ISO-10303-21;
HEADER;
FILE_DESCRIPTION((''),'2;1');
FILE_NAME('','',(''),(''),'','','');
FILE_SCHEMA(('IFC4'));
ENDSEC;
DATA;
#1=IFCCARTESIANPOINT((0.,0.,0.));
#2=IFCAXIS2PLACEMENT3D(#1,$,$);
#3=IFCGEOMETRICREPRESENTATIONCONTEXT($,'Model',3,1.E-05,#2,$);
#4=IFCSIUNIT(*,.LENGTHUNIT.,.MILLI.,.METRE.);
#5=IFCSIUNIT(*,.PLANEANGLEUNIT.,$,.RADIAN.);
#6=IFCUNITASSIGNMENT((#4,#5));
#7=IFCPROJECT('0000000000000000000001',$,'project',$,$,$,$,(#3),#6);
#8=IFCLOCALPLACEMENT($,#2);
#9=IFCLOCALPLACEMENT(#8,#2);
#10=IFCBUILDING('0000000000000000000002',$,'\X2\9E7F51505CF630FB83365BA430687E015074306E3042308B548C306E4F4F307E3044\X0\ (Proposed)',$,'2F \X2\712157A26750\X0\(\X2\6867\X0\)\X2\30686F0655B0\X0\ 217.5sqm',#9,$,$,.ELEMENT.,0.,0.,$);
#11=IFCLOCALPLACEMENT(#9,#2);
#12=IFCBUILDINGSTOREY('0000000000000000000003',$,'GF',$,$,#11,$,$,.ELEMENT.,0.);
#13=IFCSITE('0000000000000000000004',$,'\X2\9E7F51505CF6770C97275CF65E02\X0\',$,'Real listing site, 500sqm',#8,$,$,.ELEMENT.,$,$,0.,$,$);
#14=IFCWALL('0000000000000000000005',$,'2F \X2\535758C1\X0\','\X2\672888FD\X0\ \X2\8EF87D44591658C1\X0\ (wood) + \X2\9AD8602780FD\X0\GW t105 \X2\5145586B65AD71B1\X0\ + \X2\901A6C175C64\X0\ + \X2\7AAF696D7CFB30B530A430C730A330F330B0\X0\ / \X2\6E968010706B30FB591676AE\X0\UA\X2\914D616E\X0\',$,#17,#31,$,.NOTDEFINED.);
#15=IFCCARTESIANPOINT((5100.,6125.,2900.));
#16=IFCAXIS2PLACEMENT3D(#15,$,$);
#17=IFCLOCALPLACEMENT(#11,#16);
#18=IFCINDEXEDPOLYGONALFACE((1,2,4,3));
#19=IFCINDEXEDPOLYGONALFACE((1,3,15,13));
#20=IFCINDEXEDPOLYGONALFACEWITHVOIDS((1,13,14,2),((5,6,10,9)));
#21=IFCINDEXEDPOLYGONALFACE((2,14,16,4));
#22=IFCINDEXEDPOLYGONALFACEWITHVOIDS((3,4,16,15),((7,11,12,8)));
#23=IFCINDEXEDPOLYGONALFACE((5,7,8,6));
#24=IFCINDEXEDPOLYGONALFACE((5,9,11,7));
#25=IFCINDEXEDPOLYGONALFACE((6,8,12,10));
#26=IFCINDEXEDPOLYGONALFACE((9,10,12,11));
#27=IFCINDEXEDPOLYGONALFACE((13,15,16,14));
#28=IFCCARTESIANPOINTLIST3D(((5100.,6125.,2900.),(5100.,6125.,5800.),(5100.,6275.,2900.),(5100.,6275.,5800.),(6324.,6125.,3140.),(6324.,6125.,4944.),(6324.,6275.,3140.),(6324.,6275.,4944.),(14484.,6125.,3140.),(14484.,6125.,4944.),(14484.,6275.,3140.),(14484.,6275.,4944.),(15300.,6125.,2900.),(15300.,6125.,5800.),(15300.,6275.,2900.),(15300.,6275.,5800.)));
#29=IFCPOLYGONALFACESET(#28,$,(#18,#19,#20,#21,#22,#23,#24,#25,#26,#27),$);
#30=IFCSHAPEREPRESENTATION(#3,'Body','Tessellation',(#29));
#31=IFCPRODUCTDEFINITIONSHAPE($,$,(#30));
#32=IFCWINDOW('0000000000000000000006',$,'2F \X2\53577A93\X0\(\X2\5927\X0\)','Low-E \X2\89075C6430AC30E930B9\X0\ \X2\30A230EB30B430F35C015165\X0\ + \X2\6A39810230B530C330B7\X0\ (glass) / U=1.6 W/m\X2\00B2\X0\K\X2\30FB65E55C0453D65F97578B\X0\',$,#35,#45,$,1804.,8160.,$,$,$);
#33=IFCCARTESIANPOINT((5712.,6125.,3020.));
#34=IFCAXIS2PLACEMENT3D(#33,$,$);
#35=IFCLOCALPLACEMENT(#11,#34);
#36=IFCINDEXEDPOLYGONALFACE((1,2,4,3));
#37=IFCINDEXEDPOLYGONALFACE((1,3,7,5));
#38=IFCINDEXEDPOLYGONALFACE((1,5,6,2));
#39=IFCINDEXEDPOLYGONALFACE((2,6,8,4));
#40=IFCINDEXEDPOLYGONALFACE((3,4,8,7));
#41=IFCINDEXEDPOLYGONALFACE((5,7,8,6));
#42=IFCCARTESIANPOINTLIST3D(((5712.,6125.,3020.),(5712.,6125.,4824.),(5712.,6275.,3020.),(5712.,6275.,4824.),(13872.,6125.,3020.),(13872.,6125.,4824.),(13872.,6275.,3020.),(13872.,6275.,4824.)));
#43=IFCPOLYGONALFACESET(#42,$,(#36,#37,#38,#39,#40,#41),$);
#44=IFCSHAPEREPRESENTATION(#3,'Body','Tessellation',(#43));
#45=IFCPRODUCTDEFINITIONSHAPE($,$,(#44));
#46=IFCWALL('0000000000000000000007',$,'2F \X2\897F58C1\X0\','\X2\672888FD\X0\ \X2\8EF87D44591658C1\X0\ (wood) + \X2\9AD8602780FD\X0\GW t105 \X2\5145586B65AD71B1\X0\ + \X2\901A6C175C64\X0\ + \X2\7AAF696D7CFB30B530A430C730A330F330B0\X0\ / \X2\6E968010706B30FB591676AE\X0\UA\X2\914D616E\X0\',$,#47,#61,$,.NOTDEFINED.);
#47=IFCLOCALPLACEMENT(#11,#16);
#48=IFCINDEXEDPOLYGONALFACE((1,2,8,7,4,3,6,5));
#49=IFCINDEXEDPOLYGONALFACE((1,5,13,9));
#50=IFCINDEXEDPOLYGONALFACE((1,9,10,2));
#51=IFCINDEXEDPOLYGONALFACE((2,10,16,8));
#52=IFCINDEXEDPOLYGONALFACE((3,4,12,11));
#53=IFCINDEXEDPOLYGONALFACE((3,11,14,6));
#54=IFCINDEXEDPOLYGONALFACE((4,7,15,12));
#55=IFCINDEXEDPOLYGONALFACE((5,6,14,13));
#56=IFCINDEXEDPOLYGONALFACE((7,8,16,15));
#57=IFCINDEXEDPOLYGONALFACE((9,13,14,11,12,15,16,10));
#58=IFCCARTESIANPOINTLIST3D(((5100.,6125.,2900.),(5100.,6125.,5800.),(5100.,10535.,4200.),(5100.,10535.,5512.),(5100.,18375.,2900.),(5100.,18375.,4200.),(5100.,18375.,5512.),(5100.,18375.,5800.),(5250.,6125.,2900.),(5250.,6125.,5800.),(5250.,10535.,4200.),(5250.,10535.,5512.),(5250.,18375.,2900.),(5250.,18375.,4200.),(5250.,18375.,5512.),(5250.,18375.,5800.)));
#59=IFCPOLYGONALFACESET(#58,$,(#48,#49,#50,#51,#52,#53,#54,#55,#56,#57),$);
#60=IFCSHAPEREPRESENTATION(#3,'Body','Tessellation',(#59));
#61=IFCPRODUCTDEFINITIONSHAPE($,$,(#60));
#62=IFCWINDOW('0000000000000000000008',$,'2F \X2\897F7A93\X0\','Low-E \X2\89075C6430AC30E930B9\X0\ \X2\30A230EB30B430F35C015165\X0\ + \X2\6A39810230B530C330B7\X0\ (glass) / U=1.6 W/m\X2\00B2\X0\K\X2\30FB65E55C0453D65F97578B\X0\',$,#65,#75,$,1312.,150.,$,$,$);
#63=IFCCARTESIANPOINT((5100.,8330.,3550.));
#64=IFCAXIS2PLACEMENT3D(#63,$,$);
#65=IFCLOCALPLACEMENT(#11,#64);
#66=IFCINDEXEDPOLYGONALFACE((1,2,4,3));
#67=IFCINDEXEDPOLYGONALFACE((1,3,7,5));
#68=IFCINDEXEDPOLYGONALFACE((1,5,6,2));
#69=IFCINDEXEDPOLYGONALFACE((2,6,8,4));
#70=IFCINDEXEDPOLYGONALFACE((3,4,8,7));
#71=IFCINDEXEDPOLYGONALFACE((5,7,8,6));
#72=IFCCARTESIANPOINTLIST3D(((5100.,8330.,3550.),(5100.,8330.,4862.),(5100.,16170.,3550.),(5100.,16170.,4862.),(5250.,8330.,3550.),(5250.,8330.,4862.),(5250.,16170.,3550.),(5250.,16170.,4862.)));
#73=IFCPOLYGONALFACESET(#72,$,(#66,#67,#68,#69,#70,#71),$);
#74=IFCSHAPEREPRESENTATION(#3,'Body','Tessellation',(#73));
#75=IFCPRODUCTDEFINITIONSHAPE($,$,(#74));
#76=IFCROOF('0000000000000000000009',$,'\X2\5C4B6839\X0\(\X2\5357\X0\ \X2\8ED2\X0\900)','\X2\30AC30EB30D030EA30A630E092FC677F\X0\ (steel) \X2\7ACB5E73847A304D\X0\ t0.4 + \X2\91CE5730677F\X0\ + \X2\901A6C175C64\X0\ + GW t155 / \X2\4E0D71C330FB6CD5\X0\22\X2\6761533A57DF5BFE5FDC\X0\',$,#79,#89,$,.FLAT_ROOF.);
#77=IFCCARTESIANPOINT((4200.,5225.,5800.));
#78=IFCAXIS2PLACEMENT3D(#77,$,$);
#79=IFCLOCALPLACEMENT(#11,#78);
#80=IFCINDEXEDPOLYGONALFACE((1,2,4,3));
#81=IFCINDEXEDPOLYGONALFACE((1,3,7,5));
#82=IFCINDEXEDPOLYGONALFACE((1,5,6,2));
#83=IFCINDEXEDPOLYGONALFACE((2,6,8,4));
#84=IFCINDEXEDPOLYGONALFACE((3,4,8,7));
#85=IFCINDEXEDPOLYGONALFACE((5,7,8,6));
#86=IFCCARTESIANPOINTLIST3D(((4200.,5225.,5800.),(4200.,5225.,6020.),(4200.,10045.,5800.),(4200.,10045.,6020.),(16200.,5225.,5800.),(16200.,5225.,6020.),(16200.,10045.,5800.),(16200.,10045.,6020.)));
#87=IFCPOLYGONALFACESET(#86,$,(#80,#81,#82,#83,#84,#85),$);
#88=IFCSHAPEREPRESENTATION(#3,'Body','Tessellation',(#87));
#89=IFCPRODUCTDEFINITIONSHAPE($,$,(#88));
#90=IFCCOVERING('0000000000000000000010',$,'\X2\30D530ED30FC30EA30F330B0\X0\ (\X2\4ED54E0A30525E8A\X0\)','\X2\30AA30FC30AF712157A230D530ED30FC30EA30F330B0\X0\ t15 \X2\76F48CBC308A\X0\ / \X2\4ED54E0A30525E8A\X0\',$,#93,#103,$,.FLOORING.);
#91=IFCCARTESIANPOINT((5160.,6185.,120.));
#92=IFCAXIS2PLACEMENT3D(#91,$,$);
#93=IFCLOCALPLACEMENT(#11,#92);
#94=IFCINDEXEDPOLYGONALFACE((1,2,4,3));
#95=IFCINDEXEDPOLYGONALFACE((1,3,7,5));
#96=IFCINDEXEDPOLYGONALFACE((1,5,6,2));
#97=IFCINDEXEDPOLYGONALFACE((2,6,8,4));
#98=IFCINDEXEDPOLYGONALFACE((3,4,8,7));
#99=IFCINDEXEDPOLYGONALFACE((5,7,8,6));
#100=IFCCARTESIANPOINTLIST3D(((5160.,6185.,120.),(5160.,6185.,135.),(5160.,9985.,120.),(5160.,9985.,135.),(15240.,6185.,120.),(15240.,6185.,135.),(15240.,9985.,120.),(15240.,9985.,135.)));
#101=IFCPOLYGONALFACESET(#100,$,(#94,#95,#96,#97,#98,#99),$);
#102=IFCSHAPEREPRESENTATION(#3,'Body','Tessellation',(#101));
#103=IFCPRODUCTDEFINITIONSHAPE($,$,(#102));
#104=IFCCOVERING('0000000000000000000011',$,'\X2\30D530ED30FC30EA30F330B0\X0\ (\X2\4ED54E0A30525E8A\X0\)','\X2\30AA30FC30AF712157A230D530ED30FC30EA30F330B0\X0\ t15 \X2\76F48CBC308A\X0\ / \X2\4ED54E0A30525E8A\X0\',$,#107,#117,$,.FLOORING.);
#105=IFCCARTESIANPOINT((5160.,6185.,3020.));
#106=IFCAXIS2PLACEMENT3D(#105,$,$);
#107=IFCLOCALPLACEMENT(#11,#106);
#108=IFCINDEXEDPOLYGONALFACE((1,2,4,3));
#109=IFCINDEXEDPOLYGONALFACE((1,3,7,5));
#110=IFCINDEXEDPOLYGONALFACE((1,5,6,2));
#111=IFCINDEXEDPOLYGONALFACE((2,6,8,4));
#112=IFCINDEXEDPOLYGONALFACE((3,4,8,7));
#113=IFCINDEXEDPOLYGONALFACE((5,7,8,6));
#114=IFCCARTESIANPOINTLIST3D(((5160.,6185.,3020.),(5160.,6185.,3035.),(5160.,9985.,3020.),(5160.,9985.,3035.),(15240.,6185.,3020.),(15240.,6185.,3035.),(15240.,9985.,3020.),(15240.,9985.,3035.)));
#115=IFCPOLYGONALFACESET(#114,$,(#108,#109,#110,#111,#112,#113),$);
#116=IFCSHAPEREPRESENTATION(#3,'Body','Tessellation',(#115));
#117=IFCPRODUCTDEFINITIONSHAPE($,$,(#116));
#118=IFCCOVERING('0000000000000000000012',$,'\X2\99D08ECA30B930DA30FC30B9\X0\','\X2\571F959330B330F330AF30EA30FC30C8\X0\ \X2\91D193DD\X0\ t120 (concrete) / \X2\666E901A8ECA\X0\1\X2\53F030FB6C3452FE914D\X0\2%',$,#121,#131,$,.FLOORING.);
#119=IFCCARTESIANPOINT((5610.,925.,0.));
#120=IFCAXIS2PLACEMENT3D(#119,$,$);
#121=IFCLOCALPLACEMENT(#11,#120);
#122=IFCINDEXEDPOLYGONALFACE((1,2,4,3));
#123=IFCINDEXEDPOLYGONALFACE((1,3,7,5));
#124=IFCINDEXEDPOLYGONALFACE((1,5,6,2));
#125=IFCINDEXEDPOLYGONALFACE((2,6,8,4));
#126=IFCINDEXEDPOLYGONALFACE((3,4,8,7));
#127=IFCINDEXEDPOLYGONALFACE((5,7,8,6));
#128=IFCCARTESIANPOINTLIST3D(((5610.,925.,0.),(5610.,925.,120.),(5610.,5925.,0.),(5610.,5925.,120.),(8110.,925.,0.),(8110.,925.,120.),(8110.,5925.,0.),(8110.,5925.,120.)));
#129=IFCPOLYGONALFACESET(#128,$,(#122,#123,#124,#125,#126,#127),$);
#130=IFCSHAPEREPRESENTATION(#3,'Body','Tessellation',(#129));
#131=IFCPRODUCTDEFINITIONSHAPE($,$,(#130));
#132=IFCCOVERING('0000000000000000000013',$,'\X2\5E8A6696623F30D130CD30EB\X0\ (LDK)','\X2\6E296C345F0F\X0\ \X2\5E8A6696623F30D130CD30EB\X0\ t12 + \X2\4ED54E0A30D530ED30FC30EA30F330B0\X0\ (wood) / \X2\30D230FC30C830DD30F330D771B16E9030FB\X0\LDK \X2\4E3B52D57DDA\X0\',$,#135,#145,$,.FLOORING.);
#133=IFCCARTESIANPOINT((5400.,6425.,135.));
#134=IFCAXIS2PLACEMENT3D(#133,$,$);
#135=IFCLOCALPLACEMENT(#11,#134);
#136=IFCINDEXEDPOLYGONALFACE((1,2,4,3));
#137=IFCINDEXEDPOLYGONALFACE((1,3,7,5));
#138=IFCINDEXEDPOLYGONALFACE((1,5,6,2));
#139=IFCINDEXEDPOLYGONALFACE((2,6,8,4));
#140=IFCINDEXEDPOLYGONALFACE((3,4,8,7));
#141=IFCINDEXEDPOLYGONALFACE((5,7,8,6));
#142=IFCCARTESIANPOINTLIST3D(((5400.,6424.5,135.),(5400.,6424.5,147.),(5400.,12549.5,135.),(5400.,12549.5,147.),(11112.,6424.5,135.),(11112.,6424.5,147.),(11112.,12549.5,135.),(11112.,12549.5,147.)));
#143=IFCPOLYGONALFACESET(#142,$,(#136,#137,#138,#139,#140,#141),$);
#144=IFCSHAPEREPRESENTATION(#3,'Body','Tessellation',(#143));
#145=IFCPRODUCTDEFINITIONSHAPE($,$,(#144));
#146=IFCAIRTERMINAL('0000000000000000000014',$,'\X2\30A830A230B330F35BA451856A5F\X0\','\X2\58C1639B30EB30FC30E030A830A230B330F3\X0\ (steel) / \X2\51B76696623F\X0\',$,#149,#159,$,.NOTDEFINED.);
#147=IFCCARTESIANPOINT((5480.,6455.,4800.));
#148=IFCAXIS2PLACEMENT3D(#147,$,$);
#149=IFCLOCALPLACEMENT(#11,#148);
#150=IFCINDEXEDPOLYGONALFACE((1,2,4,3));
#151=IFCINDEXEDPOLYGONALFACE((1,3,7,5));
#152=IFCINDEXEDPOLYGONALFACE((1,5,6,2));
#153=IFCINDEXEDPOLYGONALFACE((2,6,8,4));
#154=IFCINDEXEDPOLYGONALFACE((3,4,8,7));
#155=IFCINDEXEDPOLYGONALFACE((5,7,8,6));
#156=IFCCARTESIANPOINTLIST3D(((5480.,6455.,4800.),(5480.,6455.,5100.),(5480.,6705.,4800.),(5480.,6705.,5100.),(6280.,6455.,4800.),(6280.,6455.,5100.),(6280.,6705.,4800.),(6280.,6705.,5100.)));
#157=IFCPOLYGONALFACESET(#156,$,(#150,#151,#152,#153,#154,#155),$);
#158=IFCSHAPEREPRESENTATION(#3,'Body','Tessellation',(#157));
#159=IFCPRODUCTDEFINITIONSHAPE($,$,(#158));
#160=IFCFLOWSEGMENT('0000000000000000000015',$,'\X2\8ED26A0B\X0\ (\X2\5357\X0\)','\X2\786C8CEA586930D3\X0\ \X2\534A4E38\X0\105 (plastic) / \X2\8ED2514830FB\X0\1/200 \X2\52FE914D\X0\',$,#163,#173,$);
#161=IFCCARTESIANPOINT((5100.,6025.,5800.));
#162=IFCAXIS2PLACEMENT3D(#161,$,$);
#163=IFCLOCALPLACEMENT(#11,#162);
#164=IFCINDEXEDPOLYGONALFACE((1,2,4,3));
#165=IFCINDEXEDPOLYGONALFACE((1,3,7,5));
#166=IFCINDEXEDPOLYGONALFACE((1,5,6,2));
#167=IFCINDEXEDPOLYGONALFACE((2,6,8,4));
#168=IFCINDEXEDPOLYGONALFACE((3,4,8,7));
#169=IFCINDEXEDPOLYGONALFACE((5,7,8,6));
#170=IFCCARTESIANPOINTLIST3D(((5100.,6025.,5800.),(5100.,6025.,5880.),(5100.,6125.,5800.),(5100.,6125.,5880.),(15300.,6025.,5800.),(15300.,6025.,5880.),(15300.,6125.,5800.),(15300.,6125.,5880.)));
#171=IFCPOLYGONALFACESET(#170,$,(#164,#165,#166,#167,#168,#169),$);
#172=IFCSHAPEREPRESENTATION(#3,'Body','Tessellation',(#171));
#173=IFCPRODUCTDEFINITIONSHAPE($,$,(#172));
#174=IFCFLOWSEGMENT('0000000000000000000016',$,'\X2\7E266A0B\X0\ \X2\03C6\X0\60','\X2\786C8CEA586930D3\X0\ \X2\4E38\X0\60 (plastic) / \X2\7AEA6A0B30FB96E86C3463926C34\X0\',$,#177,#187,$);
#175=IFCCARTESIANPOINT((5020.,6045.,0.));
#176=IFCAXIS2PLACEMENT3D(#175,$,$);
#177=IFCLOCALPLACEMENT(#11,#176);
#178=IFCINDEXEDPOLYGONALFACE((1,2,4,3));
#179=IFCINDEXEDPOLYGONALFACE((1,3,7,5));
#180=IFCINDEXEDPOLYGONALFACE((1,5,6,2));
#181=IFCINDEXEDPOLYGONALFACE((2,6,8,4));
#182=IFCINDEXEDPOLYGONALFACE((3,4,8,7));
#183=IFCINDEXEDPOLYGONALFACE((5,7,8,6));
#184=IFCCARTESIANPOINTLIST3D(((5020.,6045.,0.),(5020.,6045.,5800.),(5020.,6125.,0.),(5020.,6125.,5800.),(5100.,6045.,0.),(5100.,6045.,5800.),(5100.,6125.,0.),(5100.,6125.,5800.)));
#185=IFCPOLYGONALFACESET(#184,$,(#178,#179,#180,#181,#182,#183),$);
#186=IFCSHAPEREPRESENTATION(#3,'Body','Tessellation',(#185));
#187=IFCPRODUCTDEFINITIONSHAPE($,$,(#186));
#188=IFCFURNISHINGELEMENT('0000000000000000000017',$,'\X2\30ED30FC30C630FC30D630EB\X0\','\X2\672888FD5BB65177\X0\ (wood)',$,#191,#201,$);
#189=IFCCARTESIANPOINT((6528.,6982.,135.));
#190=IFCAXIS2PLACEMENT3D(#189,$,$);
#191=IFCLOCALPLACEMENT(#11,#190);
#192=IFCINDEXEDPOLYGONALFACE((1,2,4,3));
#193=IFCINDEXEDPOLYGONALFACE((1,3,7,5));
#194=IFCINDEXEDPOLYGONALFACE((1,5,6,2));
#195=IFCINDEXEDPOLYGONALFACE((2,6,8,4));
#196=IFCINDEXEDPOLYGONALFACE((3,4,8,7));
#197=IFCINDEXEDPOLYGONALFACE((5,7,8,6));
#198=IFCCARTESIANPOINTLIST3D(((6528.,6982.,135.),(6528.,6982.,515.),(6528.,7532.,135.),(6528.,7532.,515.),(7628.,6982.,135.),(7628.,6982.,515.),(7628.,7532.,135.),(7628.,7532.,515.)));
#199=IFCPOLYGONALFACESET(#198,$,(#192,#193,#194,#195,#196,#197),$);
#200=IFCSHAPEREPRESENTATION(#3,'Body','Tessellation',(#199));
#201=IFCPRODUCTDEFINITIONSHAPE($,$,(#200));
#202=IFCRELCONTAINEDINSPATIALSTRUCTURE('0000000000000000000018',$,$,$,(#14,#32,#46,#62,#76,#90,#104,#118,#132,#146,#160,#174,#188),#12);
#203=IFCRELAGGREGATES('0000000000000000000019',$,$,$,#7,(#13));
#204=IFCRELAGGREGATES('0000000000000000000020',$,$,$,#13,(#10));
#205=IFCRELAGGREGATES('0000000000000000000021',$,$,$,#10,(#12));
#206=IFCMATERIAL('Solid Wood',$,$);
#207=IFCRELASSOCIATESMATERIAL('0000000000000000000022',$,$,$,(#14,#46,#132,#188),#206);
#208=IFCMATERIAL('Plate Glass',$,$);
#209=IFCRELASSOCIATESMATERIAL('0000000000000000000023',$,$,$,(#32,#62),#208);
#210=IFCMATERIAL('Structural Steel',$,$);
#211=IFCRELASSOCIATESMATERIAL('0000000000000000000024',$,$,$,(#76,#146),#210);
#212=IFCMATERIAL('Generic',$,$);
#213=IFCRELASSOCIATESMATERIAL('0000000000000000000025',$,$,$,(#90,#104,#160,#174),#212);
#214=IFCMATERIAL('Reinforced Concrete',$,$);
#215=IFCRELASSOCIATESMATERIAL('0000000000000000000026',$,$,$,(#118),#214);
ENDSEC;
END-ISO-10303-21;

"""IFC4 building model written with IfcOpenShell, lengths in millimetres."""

from ifc_helpers import new_model, si_unit, frame, frame_2d, origin, place, context, project, spatial, rectangle, extrude, material, element, fill, save


model = new_model("IFC4")

# Units and contexts
model_context = context("Model", 3, precision=1e-05, world=origin())
ifc_project = project(units=[si_unit("LENGTHUNIT", "METRE", prefix="MILLI"), si_unit("PLANEANGLEUNIT", "RADIAN")], contexts=[model_context])

# Site, building, storey
site_placement = place(None, origin())
site = spatial("IfcSite", under=ifc_project, at=site_placement, Name="鹿児島県霧島市", ObjectType="Real listing site, 500sqm", CompositionType="ELEMENT", RefElevation=0.0)
building_placement = place(site_placement, origin())
building = spatial("IfcBuilding", under=site, at=building_placement, Name="鹿児島・茶室と縁側のある和の住まい (Proposed)", ObjectType="2F 無垢材(桧)と漆喰 217.5sqm", CompositionType="ELEMENT", ElevationOfRefHeight=0.0, ElevationOfTerrain=0.0)
storey_placement = place(building_placement, origin())
storey = spatial("IfcBuildingStorey", under=building, at=storey_placement, Name="GF", CompositionType="ELEMENT", Elevation=0.0)

# Shared definitions
ifc_material_1 = material(Name="Solid Wood")

# Shared definitions
ifc_material_2 = material(Name="Reinforced Concrete")

# Shared definitions
ifc_material_3 = material(Name="Plate Glass")

# Walls, openings, windows
wall_1_placement = place(storey_placement, frame((5100.0, 6125.0, 2900.0)))
wall_1 = element("IfcWall", 1, at=wall_1_placement, inside=storey, material=ifc_material_1, Name="2F 南壁", Description="木製 軸組外壁 (wood) + 高性能GW t105 充填断熱 + 通気層 + 窯業系サイディング / 準耐火・外皮UA配慮", PredefinedType="NOTDEFINED", context=model_context, shape_type="SweptSolid", body=[
    extrude(rectangle(XDim=10200.0, YDim=150.0, at=frame_2d((5100.0, 75.0))), frame((5100.0, 6125.0, 2900.0)), (0.0, 0.0, 1.0), 2900.0),
])
opening_1_placement = place(storey_placement, frame((5712.0, 6125.0, 3020.0)))
opening_1 = element("IfcOpeningElement", 2, at=opening_1_placement, cuts=wall_1, PredefinedType="NOTDEFINED", context=model_context, shape_type="SweptSolid", body=[
    extrude(rectangle(XDim=8160.0, YDim=150.0, at=frame_2d((4080.0, 75.0))), frame((5712.0, 6125.0, 3020.0)), (0.0, 0.0, 1.0), 1804.0),
])
window_1_placement = place(storey_placement, frame((5712.0, 6125.0, 3020.0)))
window_1 = element("IfcWindow", 3, at=window_1_placement, inside=storey, material=ifc_material_3, Name="2F 南窓(大)", Description="Low-E 複層ガラス アルゴン封入 + 樹脂サッシ (glass) / U=1.6 W/m²K・日射取得型", OverallHeight=1804.0, OverallWidth=8160.0, context=model_context, shape_type="SweptSolid", body=[
    extrude(rectangle(XDim=8160.0, YDim=150.0, at=frame_2d((4080.0, 75.0))), frame((5712.0, 6125.0, 3020.0)), (0.0, 0.0, 1.0), 1804.0),
])
fill(opening_1, window_1)
wall_2_placement = place(storey_placement, frame((5100.0, 6125.0, 2900.0)))
wall_2 = element("IfcWall", 4, at=wall_2_placement, inside=storey, material=ifc_material_1, Name="2F 西壁", Description="木製 軸組外壁 (wood) + 高性能GW t105 充填断熱 + 通気層 + 窯業系サイディング / 準耐火・外皮UA配慮", PredefinedType="NOTDEFINED", context=model_context, shape_type="SweptSolid", body=[
    extrude(rectangle(XDim=150.0, YDim=12250.0, at=frame_2d((75.0, 6125.0))), frame((5100.0, 6125.0, 2900.0)), (0.0, 0.0, 1.0), 2900.0),
])
opening_2_placement = place(storey_placement, frame((5100.0, 8330.0, 3550.0)))
opening_2 = element("IfcOpeningElement", 5, at=opening_2_placement, cuts=wall_2, PredefinedType="NOTDEFINED", context=model_context, shape_type="SweptSolid", body=[
    extrude(rectangle(XDim=150.0, YDim=7840.0, at=frame_2d((75.0, 3920.0))), frame((5100.0, 8330.0, 3550.0)), (0.0, 0.0, 1.0), 1312.0),
])
window_2_placement = place(storey_placement, frame((5100.0, 8330.0, 3550.0)))
window_2 = element("IfcWindow", 6, at=window_2_placement, inside=storey, material=ifc_material_3, Name="2F 西窓", Description="Low-E 複層ガラス アルゴン封入 + 樹脂サッシ (glass) / U=1.6 W/m²K・日射取得型", OverallHeight=1312.0, OverallWidth=150.0, context=model_context, shape_type="SweptSolid", body=[
    extrude(rectangle(XDim=150.0, YDim=7840.0, at=frame_2d((75.0, 3920.0))), frame((5100.0, 8330.0, 3550.0)), (0.0, 0.0, 1.0), 1312.0),
])
fill(opening_2, window_2)

# Roof
ifc_material_4 = material(Name="Structural Steel")
for number, where, name in (
    (7, (4200.0, 5225.0, 5800.0), "屋根(南 軒900)"),
):
    element("IfcRoof", number, at=place(storey_placement, frame(where)), inside=storey, material=ifc_material_4, Name=name, Description="ガルバリウム鋼板 (steel) 立平葺き t0.4 + 野地板 + 通気層 + GW t155 / 不燃・法22条区域対応", PredefinedType="FLAT_ROOF", context=model_context, shape_type="SweptSolid", body=[
        extrude(rectangle(XDim=12000.0, YDim=4820.0, at=frame_2d((6000.0, 2410.0))), frame((4200.0, 5225.0, 5800.0)), (0.0, 0.0, 1.0), 220.0),
    ])

# Coverings
ifc_material_5 = material(Name="Generic")
covering_1_placement = place(storey_placement, frame((5160.0, 6185.0, 120.0)))
element("IfcCovering", 8, at=covering_1_placement, inside=storey, material=ifc_material_5, Name="フローリング (仕上げ床)", Description="オーク無垢フローリング t15 直貼り / 仕上げ床", PredefinedType="FLOORING", context=model_context, shape_type="SweptSolid", body=[
    extrude(rectangle(XDim=10080.0, YDim=3800.0, at=frame_2d((5040.0, 1900.0))), frame((5160.0, 6185.0, 120.0)), (0.0, 0.0, 1.0), 15.0),
])
covering_2_placement = place(storey_placement, frame((5160.0, 6185.0, 3020.0)))
element("IfcCovering", 9, at=covering_2_placement, inside=storey, material=ifc_material_5, Name="フローリング (仕上げ床)", Description="オーク無垢フローリング t15 直貼り / 仕上げ床", PredefinedType="FLOORING", context=model_context, shape_type="SweptSolid", body=[
    extrude(rectangle(XDim=10080.0, YDim=3800.0, at=frame_2d((5040.0, 1900.0))), frame((5160.0, 6185.0, 3020.0)), (0.0, 0.0, 1.0), 15.0),
])
covering_3_placement = place(storey_placement, frame((5610.0, 925.0, 0.0)))
element("IfcCovering", 10, at=covering_3_placement, inside=storey, material=ifc_material_2, Name="駐車スペース", Description="土間コンクリート 金鏝 t120 (concrete) / 普通車1台・水勾配2%", PredefinedType="FLOORING", context=model_context, shape_type="SweptSolid", body=[
    extrude(rectangle(XDim=2500.0, YDim=5000.0, at=frame_2d((1250.0, 2500.0))), frame((5610.0, 925.0, 0.0)), (0.0, 0.0, 1.0), 120.0),
])
covering_4_placement = place(storey_placement, frame((5400.0, 6425.0, 135.0)))
element("IfcCovering", 11, at=covering_4_placement, inside=storey, material=ifc_material_1, Name="床暖房パネル (LDK)", Description="温水式 床暖房パネル t12 + 仕上フローリング (wood) / ヒートポンプ熱源・LDK 主動線", PredefinedType="FLOORING", context=model_context, shape_type="SweptSolid", body=[
    extrude(rectangle(XDim=5712.0, YDim=6125.0, at=frame_2d((2856.0, 3062.0))), frame((5400.0, 6425.0, 135.0)), (0.0, 0.0, 1.0), 12.0),
])

# Air terminal
air_terminal_placement = place(storey_placement, frame((5480.0, 6455.0, 4800.0)))
element("IfcAirTerminal", 12, at=air_terminal_placement, inside=storey, material=ifc_material_4, Name="エアコン室内機", Description="壁掛ルームエアコン (steel) / 冷暖房", PredefinedType="NOTDEFINED", context=model_context, shape_type="SweptSolid", body=[
    extrude(rectangle(XDim=800.0, YDim=250.0, at=frame_2d((400.0, 125.0))), frame((5480.0, 6455.0, 4800.0)), (0.0, 0.0, 1.0), 300.0),
])

# Flow segments
flow_segment_1_placement = place(storey_placement, frame((5100.0, 6025.0, 5800.0)))
element("IfcFlowSegment", 13, at=flow_segment_1_placement, inside=storey, material=ifc_material_5, Name="軒樋 (南)", Description="硬質塩ビ 半丸105 (plastic) / 軒先・1/200 勾配", context=model_context, shape_type="SweptSolid", body=[
    extrude(rectangle(XDim=10200.0, YDim=100.0, at=frame_2d((5100.0, 50.0))), frame((5100.0, 6025.0, 5800.0)), (0.0, 0.0, 1.0), 80.0),
])
flow_segment_2_placement = place(storey_placement, frame((5020.0, 6045.0, 0.0)))
element("IfcFlowSegment", 14, at=flow_segment_2_placement, inside=storey, material=ifc_material_5, Name="縦樋 φ60", Description="硬質塩ビ 丸60 (plastic) / 竪樋・雨水排水", context=model_context, shape_type="SweptSolid", body=[
    extrude(rectangle(XDim=80.0, YDim=80.0, at=frame_2d((40.0, 40.0))), frame((5020.0, 6045.0, 0.0)), (0.0, 0.0, 1.0), 5800.0),
])

# Furnishing element
furnishing_1_placement = place(storey_placement, frame((6528.0, 6982.0, 135.0)))
element("IfcFurnishingElement", 15, at=furnishing_1_placement, inside=storey, material=ifc_material_1, Name="ローテーブル", Description="木製家具 (wood)", context=model_context, shape_type="SweptSolid", body=[
    extrude(rectangle(XDim=1100.0, YDim=550.0, at=frame_2d((550.0, 275.0))), frame((6528.0, 6982.0, 135.0)), (0.0, 0.0, 1.0), 380.0),
])

save(model, "model.ifc")
